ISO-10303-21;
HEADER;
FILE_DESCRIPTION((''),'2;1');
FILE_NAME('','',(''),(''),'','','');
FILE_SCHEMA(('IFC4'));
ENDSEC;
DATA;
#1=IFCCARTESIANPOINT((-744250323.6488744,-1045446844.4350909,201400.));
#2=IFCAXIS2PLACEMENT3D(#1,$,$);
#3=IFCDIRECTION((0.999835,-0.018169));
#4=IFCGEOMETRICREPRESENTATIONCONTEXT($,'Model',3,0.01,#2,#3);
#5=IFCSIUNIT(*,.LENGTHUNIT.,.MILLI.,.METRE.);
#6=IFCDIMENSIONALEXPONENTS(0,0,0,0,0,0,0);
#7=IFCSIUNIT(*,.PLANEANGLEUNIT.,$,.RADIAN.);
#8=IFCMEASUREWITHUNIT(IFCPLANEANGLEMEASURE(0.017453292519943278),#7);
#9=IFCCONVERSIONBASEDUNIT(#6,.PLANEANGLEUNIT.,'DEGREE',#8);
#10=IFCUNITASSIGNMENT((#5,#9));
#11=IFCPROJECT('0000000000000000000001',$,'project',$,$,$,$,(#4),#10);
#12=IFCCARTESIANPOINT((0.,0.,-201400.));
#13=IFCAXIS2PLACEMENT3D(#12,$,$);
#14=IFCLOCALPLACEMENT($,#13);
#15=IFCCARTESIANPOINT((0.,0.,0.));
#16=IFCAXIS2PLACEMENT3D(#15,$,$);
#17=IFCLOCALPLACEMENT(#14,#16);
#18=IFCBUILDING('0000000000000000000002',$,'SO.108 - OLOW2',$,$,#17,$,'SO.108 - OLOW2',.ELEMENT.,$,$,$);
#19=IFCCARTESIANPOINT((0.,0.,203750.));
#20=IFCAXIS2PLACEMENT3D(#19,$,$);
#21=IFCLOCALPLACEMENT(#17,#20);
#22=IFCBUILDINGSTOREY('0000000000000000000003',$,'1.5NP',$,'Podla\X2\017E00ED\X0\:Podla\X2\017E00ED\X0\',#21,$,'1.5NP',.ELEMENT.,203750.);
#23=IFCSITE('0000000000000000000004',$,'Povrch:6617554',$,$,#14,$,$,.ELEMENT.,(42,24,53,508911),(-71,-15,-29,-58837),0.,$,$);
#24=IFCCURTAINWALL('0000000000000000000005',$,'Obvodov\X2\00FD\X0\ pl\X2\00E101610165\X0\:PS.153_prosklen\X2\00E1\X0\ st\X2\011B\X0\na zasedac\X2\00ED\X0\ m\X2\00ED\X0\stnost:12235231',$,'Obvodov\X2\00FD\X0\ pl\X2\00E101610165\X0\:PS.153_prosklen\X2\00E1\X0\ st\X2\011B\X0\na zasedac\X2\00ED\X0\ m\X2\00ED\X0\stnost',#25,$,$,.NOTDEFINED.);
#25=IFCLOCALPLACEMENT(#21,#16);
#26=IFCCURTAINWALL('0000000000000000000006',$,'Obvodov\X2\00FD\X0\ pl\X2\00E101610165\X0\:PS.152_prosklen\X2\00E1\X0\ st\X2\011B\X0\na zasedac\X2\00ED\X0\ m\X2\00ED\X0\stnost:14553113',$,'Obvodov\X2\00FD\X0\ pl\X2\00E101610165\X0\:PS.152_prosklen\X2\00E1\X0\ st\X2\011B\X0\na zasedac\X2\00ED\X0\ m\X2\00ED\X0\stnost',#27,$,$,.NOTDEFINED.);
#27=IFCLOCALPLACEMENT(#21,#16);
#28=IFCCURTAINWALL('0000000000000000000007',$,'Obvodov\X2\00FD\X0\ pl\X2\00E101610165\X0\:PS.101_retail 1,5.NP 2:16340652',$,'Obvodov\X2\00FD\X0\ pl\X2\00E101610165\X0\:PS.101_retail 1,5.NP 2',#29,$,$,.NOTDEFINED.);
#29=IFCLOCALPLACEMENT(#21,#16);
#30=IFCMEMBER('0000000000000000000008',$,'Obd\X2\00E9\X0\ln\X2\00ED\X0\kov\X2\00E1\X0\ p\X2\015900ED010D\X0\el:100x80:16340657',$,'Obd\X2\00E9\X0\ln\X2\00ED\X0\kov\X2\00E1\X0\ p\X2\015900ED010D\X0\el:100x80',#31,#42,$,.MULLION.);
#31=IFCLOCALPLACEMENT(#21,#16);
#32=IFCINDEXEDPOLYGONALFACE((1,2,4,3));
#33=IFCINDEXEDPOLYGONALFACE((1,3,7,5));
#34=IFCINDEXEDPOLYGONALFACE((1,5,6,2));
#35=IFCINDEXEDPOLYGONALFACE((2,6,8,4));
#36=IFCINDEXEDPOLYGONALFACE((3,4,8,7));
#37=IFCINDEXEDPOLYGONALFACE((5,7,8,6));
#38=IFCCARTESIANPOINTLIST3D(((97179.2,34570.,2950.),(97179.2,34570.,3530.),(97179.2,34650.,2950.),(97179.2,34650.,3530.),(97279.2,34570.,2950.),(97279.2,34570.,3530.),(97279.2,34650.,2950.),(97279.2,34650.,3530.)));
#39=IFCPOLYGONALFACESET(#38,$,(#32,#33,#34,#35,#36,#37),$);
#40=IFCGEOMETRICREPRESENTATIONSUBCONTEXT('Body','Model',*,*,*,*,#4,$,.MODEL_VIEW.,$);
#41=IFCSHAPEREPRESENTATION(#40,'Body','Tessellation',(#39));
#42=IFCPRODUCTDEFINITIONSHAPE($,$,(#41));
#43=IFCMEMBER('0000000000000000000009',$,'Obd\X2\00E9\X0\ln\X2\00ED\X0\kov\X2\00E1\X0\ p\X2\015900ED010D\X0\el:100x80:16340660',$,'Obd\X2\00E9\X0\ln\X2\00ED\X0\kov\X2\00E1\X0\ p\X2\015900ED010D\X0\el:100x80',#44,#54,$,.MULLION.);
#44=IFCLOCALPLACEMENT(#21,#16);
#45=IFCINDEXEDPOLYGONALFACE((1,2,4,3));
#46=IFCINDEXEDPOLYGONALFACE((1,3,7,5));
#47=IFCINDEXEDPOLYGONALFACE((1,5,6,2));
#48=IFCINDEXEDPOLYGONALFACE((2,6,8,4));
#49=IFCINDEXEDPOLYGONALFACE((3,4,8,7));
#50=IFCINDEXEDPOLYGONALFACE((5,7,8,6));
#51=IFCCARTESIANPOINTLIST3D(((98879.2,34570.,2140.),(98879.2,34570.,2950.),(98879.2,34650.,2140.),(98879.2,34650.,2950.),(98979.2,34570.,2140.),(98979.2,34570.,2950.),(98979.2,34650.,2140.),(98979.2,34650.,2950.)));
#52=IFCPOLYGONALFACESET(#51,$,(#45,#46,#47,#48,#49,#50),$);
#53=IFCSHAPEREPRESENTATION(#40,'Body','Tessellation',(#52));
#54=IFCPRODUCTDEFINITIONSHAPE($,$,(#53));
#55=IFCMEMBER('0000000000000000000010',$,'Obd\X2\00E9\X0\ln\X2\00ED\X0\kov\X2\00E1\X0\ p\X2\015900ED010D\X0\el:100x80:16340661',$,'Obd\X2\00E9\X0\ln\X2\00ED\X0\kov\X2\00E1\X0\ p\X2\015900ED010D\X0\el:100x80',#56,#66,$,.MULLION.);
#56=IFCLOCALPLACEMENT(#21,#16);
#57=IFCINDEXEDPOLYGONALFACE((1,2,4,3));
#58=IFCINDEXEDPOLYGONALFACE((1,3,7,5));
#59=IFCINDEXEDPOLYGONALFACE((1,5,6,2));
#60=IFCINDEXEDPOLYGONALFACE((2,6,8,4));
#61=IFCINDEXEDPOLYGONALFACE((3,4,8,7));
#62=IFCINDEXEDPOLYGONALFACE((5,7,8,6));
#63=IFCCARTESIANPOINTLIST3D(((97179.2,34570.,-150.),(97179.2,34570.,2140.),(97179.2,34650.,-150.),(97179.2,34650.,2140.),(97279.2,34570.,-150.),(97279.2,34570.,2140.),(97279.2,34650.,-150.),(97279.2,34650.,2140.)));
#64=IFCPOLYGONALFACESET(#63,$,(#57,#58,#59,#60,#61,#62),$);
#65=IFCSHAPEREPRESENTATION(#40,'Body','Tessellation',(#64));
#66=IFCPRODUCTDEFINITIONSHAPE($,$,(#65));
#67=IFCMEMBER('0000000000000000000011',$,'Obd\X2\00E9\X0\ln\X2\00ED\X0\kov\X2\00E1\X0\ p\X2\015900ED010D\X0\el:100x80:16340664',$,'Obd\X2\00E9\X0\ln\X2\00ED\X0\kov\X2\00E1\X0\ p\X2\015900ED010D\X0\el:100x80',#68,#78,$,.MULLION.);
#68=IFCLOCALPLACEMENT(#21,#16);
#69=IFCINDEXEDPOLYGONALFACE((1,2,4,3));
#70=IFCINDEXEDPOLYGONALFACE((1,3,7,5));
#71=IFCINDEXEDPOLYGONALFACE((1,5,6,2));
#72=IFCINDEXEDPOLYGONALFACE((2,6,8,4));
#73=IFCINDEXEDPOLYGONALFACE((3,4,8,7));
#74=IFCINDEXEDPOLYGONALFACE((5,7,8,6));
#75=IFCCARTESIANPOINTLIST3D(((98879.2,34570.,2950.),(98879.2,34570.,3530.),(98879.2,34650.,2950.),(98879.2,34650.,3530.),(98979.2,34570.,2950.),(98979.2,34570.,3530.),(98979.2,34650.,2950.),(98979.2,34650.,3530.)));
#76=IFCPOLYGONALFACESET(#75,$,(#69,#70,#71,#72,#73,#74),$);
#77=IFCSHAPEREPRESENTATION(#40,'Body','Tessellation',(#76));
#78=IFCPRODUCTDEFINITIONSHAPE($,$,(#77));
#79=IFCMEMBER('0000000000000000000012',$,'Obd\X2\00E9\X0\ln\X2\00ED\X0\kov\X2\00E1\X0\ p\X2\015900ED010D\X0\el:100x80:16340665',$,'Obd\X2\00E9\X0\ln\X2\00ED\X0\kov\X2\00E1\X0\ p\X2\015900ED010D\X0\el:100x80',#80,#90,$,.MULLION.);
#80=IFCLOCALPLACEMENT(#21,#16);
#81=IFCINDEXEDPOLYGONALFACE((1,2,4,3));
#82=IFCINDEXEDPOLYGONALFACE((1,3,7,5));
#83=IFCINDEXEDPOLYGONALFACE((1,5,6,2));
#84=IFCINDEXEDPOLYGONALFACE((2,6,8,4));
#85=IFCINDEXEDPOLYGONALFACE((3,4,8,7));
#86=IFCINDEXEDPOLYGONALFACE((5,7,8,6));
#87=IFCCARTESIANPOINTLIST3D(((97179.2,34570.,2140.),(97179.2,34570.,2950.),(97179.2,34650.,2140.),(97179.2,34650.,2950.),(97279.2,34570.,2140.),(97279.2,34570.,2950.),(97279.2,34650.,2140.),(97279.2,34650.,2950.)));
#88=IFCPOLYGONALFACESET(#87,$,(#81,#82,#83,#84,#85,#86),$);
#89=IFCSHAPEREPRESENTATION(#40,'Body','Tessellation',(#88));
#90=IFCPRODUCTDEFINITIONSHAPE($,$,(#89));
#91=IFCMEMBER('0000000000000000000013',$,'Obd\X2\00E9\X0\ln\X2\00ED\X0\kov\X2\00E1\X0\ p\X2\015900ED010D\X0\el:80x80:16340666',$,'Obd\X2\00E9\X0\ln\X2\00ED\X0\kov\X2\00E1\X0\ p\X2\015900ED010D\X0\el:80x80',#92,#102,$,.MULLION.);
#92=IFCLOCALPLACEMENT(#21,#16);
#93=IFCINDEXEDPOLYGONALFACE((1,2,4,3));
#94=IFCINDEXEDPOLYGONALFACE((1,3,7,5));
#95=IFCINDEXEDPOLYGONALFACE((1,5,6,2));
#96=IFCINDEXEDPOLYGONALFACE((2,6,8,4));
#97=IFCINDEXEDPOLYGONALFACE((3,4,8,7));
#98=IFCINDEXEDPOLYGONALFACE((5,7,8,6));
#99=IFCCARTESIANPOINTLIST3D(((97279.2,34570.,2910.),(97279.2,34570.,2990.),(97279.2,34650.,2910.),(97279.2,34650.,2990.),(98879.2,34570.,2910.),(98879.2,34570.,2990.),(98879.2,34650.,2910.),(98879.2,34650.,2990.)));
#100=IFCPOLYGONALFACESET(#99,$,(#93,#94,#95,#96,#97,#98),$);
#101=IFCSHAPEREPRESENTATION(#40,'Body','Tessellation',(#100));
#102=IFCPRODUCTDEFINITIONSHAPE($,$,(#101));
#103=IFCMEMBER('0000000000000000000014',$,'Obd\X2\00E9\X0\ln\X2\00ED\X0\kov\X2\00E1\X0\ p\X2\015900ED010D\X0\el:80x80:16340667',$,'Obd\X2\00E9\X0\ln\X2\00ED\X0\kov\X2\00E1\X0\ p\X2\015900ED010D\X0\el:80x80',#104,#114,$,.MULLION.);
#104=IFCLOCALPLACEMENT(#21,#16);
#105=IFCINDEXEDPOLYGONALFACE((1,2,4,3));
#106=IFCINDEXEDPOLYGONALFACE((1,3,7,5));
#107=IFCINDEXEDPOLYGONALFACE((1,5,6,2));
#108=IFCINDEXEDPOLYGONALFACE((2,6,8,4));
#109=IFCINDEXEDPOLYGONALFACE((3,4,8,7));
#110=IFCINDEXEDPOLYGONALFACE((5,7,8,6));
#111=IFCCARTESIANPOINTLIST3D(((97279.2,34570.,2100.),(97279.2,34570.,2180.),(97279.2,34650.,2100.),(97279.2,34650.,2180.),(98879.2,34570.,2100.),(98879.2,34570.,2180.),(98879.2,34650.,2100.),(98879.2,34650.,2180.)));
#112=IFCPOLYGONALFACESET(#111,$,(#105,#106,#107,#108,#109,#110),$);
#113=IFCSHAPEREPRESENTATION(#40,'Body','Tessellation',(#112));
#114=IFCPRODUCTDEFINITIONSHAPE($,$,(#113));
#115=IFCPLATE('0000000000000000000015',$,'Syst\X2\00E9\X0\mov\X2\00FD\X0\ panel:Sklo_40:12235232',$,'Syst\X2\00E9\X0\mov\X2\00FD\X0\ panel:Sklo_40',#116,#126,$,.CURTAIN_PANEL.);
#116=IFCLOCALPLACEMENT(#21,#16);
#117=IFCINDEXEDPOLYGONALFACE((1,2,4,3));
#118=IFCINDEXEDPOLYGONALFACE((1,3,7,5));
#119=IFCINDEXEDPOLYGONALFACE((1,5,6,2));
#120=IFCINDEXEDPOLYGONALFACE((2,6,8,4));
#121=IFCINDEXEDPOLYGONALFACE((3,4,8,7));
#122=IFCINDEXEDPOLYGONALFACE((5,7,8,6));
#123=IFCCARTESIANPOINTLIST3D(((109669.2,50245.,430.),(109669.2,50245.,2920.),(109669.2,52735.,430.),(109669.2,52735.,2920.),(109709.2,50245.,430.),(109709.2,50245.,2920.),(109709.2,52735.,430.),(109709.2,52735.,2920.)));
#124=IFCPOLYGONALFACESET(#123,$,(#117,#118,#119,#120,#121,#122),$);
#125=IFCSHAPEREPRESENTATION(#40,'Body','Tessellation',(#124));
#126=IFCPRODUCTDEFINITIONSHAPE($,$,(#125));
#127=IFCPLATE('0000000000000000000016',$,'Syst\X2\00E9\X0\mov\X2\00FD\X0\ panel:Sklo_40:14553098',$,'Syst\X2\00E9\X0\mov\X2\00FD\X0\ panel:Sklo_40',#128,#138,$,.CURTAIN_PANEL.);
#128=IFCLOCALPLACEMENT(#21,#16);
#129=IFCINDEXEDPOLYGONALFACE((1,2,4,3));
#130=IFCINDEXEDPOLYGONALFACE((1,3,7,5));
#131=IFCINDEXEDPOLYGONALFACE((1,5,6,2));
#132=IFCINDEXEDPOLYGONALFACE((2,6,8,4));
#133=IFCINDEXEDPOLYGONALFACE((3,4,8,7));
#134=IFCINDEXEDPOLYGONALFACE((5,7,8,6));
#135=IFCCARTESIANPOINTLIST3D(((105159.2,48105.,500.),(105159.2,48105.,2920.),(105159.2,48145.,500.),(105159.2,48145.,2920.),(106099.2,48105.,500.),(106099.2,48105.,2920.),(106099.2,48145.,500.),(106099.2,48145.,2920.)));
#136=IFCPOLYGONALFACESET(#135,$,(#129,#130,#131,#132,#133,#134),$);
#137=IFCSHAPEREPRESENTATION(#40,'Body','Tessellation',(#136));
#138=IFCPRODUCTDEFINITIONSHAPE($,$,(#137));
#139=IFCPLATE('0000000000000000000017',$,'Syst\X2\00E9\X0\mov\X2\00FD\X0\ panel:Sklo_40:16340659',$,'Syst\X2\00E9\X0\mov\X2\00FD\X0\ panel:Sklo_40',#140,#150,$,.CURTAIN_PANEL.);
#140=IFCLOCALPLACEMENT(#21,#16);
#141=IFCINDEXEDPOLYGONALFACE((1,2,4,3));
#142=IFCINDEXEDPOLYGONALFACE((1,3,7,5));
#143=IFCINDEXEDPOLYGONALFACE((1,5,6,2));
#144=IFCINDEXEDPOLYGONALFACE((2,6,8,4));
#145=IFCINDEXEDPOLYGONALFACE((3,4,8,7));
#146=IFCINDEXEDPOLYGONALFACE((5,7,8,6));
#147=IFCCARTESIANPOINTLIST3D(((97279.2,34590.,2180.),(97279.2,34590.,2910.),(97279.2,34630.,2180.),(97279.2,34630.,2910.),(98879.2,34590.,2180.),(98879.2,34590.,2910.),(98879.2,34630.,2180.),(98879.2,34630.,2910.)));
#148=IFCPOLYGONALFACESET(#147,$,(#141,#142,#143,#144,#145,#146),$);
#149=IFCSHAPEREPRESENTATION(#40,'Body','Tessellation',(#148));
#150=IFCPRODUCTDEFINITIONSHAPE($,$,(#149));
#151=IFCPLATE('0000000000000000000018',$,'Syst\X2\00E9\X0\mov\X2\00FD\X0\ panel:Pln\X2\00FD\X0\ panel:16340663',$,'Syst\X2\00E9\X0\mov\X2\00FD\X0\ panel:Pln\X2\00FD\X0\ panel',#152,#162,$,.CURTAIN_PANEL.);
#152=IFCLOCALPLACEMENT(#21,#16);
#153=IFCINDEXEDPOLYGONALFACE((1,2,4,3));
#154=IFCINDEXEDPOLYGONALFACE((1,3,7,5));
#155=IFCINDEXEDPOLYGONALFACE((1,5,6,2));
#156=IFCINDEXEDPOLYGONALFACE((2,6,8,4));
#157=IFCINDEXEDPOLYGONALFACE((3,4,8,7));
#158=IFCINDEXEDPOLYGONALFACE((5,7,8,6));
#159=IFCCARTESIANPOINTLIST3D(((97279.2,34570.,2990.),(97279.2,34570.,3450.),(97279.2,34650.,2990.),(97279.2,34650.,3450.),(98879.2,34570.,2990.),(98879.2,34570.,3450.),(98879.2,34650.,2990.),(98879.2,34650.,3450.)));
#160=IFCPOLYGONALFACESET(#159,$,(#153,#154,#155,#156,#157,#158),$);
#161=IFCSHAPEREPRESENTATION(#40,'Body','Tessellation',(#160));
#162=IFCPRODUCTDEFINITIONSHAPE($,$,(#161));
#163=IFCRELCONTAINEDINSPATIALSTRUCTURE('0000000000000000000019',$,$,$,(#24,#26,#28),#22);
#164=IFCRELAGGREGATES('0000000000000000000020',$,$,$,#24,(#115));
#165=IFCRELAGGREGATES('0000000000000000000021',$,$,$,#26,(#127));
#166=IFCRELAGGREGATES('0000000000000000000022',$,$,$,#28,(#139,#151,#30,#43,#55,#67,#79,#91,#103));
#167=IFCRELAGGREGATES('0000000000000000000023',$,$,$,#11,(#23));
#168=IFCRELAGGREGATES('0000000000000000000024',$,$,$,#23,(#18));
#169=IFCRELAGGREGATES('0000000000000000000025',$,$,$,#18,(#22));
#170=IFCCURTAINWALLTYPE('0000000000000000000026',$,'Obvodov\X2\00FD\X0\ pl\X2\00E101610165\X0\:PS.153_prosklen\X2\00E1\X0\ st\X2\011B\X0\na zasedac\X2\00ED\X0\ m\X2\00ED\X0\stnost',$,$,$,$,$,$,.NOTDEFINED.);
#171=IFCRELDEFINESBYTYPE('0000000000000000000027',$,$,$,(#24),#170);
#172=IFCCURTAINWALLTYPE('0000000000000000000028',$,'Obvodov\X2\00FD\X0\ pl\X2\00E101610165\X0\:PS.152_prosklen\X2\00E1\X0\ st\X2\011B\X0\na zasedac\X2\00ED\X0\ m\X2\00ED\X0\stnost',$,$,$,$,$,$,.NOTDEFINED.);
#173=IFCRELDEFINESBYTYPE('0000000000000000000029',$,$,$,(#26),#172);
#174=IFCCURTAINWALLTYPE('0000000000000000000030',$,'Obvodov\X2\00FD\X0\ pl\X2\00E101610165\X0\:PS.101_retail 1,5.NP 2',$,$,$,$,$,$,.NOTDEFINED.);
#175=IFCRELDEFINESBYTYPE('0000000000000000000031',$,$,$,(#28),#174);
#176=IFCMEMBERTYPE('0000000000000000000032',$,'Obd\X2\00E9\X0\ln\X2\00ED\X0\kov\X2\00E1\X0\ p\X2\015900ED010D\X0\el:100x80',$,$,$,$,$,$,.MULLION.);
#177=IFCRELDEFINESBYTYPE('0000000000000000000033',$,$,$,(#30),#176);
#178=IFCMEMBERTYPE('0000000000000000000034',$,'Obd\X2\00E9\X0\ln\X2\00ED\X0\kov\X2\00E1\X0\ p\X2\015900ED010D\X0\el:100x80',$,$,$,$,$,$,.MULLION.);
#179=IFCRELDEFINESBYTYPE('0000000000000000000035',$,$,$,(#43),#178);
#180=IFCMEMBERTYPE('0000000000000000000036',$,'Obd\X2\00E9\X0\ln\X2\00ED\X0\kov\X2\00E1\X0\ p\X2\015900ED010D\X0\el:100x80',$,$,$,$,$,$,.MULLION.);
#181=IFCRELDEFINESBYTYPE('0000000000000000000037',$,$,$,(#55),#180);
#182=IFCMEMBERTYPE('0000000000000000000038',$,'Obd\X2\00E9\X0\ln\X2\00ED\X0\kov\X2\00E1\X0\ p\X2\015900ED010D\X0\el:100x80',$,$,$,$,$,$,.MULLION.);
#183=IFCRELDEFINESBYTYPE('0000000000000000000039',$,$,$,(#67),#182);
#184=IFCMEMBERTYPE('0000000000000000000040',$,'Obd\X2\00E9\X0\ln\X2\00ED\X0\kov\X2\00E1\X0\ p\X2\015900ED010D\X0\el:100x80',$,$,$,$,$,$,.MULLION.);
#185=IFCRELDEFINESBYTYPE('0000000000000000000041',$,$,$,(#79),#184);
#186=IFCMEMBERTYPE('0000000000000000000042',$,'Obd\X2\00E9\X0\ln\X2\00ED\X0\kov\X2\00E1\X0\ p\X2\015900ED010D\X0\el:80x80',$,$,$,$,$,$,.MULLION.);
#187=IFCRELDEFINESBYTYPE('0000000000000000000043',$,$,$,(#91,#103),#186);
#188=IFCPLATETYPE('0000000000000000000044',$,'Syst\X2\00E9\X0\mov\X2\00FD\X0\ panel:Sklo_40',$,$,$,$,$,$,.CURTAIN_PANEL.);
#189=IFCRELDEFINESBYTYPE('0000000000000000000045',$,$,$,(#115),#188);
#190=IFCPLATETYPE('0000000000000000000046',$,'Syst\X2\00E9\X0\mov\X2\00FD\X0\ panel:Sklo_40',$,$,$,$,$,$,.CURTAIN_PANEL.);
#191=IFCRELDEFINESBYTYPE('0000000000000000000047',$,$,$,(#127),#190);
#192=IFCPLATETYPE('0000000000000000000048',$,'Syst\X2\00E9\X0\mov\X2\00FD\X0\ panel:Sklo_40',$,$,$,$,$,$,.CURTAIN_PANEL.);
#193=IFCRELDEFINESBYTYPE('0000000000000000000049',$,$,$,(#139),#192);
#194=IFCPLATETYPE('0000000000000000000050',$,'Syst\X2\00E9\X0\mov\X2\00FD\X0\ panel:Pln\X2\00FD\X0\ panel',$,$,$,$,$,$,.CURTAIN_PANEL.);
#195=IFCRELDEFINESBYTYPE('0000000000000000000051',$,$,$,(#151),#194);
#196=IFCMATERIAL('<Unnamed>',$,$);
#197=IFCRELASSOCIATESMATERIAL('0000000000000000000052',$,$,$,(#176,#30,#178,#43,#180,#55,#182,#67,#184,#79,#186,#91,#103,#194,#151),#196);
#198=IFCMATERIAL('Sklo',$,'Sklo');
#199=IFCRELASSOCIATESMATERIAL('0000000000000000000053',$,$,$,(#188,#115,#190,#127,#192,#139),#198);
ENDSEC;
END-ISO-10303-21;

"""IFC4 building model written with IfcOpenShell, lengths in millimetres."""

from ifc_helpers import new_model, entity, si_unit, converted_unit, direction, frame, origin, place, context, subcontext, project, spatial, indexed_curve, outline, extrude, source, transform, mapped, material, type_object, type_shapes, element, aggregate, save


model = new_model("IFC4")

# Units and contexts
model_context = context("Model", 3, precision=0.01, world=frame((-744250323.6488744, -1045446844.4350909, 201400.0)), true_north=direction((0.999835, -0.018169)))
body_context = subcontext(model_context, "Body", "Model", "MODEL_VIEW")
ifc_project = project(units=[si_unit("LENGTHUNIT", "METRE", prefix="MILLI"), converted_unit("PLANEANGLEUNIT", "DEGREE", entity("IfcPlaneAngleMeasure", 0.017453292519943278), si_unit("PLANEANGLEUNIT", "RADIAN"), dimensions=[0, 0, 0, 0, 0, 0, 0])], contexts=[model_context])

# Site, building, storey
site_placement = place(None, frame((0.0, 0.0, -201400.0)))
site = spatial("IfcSite", under=ifc_project, at=site_placement, Name="Povrch:6617554", CompositionType="ELEMENT", RefLatitude=(42, 24, 53, 508911), RefLongitude=(-71, -15, -29, -58837), RefElevation=0.0)
building_placement = place(site_placement, origin())
building = spatial("IfcBuilding", under=site, at=building_placement, Name="SO.108 - OLOW2", LongName="SO.108 - OLOW2", CompositionType="ELEMENT")
storey_placement = place(building_placement, frame((0.0, 0.0, 203750.0)))
storey = spatial("IfcBuildingStorey", under=building, at=storey_placement, Name="1.5NP", ObjectType="Podlaží:Podlaží", LongName="1.5NP", CompositionType="ELEMENT", Elevation=203750.0)

# Curtain wall
curtain_wall_type_1 = type_object("IfcCurtainWallType", Name="Obvodový plášť:PS.153_prosklená stěna zasedací místnost", PredefinedType="NOTDEFINED")
curtain_wall_1_placement = place(storey_placement, frame((0.0, 0.0, -203750.0)))
curtain_wall_1 = element("IfcCurtainWall", 1, at=curtain_wall_1_placement, inside=storey, type_object=curtain_wall_type_1, Name="Obvodový plášť:PS.153_prosklená stěna zasedací místnost:12235231", ObjectType="Obvodový plášť:PS.153_prosklená stěna zasedací místnost", PredefinedType="NOTDEFINED")
ifc_material_1 = material(Name="<Unnamed>")

# Curtain wall
curtain_wall_type_2 = type_object("IfcCurtainWallType", Name="Obvodový plášť:PS.152_prosklená stěna zasedací místnost", PredefinedType="NOTDEFINED")
curtain_wall_2_placement = place(storey_placement, frame((0.0, 0.0, -203750.0)))
curtain_wall_2 = element("IfcCurtainWall", 2, at=curtain_wall_2_placement, inside=storey, type_object=curtain_wall_type_2, Name="Obvodový plášť:PS.152_prosklená stěna zasedací místnost:14553113", ObjectType="Obvodový plášť:PS.152_prosklená stěna zasedací místnost", PredefinedType="NOTDEFINED")

# Curtain wall, members
curtain_wall_type_3 = type_object("IfcCurtainWallType", Name="Obvodový plášť:PS.101_retail 1,5.NP 2", PredefinedType="NOTDEFINED")
curtain_wall_3_placement = place(storey_placement, frame((0.0, 0.0, -203750.0)))
curtain_wall_3 = element("IfcCurtainWall", 3, at=curtain_wall_3_placement, inside=storey, type_object=curtain_wall_type_3, Name="Obvodový plášť:PS.101_retail 1,5.NP 2:16340652", ObjectType="Obvodový plášť:PS.101_retail 1,5.NP 2", PredefinedType="NOTDEFINED")
member_type_1 = type_object("IfcMemberType", Name="Obdélníková příčel:100x80", PredefinedType="MULLION", material=ifc_material_1)
shared_shape_1 = source(origin(), body_context, "Body", "SweptSolid", [
    extrude(outline(indexed_curve([(-50.0, -40.0), (50.0, -40.0), (50.0, 40.0), (-50.0, 40.0), (-50.0, -40.0)], self_intersect=False)), frame((-50.0, 0.0, -580.0), z_axis=(0.0, 0.0, 1.0), x_axis=(-1.0, 0.0, 0.0)), (0.0, 0.0, 1.0), 580.0),
])
type_shapes(member_type_1, [shared_shape_1])
member_1_placement = place(curtain_wall_3_placement, frame((97179.2, 34610.0, 207280.0), z_axis=(0.0, 0.0, 1.0), x_axis=(-1.0, 0.0, 0.0)))
member_1 = element("IfcMember", 4, at=member_1_placement, type_object=member_type_1, material=ifc_material_1, Name="Obdélníková příčel:100x80:16340657", ObjectType="Obdélníková příčel:100x80", PredefinedType="MULLION", context=body_context, shape_type="MappedRepresentation", body=[
    mapped(shared_shape_1, transform((0.0, 0.0, 0.0), scale=1.0)),
])
member_type_2 = type_object("IfcMemberType", Name="Obdélníková příčel:100x80", PredefinedType="MULLION", material=ifc_material_1)
shared_shape_2 = source(origin(), body_context, "Body", "SweptSolid", [
    extrude(outline(indexed_curve([(-50.0, -40.0), (50.0, -40.0), (50.0, 40.0), (-50.0, 40.0), (-50.0, -40.0)], self_intersect=False)), frame((-50.0, 0.0, -810.0), z_axis=(0.0, 0.0, 1.0), x_axis=(-1.0, 0.0, 0.0)), (0.0, 0.0, 1.0), 810.0),
])
type_shapes(member_type_2, [shared_shape_2])
member_2_placement = place(curtain_wall_3_placement, frame((98979.2, 34610.0, 205890.0), z_axis=(0.0, 0.0, -1.0), x_axis=(1.0, 0.0, 0.0)))
member_2 = element("IfcMember", 5, at=member_2_placement, type_object=member_type_2, material=ifc_material_1, Name="Obdélníková příčel:100x80:16340660", ObjectType="Obdélníková příčel:100x80", PredefinedType="MULLION", context=body_context, shape_type="MappedRepresentation", body=[
    mapped(shared_shape_2, transform((0.0, 0.0, 0.0), scale=1.0)),
])
member_type_3 = type_object("IfcMemberType", Name="Obdélníková příčel:100x80", PredefinedType="MULLION", material=ifc_material_1)
shared_shape_3 = source(origin(), body_context, "Body", "SweptSolid", [
    extrude(outline(indexed_curve([(-50.0, -40.0), (50.0, -40.0), (50.0, 40.0), (-50.0, 40.0), (-50.0, -40.0)], self_intersect=False)), frame((-50.0, 0.0, -2290.0), z_axis=(0.0, 0.0, 1.0), x_axis=(-1.0, 0.0, 0.0)), (0.0, 0.0, 1.0), 2290.0),
])
type_shapes(member_type_3, [shared_shape_3])
member_3_placement = place(curtain_wall_3_placement, frame((97179.2, 34610.0, 205890.0), z_axis=(0.0, 0.0, 1.0), x_axis=(-1.0, 0.0, 0.0)))
member_3 = element("IfcMember", 6, at=member_3_placement, type_object=member_type_3, material=ifc_material_1, Name="Obdélníková příčel:100x80:16340661", ObjectType="Obdélníková příčel:100x80", PredefinedType="MULLION", context=body_context, shape_type="MappedRepresentation", body=[
    mapped(shared_shape_3, transform((0.0, 0.0, 0.0), scale=1.0)),
])
member_type_4 = type_object("IfcMemberType", Name="Obdélníková příčel:100x80", PredefinedType="MULLION", material=ifc_material_1)
shared_shape_4 = source(origin(), body_context, "Body", "SweptSolid", [
    extrude(outline(indexed_curve([(-50.0, -40.0), (50.0, -40.0), (50.0, 40.0), (-50.0, 40.0), (-50.0, -40.0)], self_intersect=False)), frame((-50.0, 0.0, -580.0), z_axis=(0.0, 0.0, 1.0), x_axis=(-1.0, 0.0, 0.0)), (0.0, 0.0, 1.0), 580.0),
])
type_shapes(member_type_4, [shared_shape_4])
member_4_placement = place(curtain_wall_3_placement, frame((98979.2, 34610.0, 206700.0), z_axis=(0.0, 0.0, -1.0), x_axis=(1.0, 0.0, 0.0)))
member_4 = element("IfcMember", 7, at=member_4_placement, type_object=member_type_4, material=ifc_material_1, Name="Obdélníková příčel:100x80:16340664", ObjectType="Obdélníková příčel:100x80", PredefinedType="MULLION", context=body_context, shape_type="MappedRepresentation", body=[
    mapped(shared_shape_4, transform((0.0, 0.0, 0.0), scale=1.0)),
])
member_type_5 = type_object("IfcMemberType", Name="Obdélníková příčel:100x80", PredefinedType="MULLION", material=ifc_material_1)
shared_shape_5 = source(origin(), body_context, "Body", "SweptSolid", [
    extrude(outline(indexed_curve([(-50.0, -40.0), (50.0, -40.0), (50.0, 40.0), (-50.0, 40.0), (-50.0, -40.0)], self_intersect=False)), frame((-50.0, 0.0, -810.0), z_axis=(0.0, 0.0, 1.0), x_axis=(-1.0, 0.0, 0.0)), (0.0, 0.0, 1.0), 810.0),
])
type_shapes(member_type_5, [shared_shape_5])
member_5_placement = place(curtain_wall_3_placement, frame((97179.2, 34610.0, 206700.0), z_axis=(0.0, 0.0, 1.0), x_axis=(-1.0, 0.0, 0.0)))
member_5 = element("IfcMember", 8, at=member_5_placement, type_object=member_type_5, material=ifc_material_1, Name="Obdélníková příčel:100x80:16340665", ObjectType="Obdélníková příčel:100x80", PredefinedType="MULLION", context=body_context, shape_type="MappedRepresentation", body=[
    mapped(shared_shape_5, transform((0.0, 0.0, 0.0), scale=1.0)),
])
member_type_6 = type_object("IfcMemberType", Name="Obdélníková příčel:80x80", PredefinedType="MULLION", material=ifc_material_1)
shared_shape_6 = source(origin(), body_context, "Body", "SweptSolid", [
    extrude(outline(indexed_curve([(-40.0, -40.0), (40.0, -40.0), (40.0, 40.0), (-40.0, 40.0), (-40.0, -40.0)], self_intersect=False)), frame((0.0, 0.0, -1600.0), z_axis=(0.0, 0.0, 1.0), x_axis=(-1.0, 0.0, 0.0)), (0.0, 0.0, 1.0), 1600.0),
])
type_shapes(member_type_6, [shared_shape_6])
member_6_placement = place(curtain_wall_3_placement, frame((98879.2, 34610.0, 206700.0), z_axis=(1.0, 0.0, 0.0), x_axis=(0.0, 0.0, 1.0)))
member_6 = element("IfcMember", 9, at=member_6_placement, type_object=member_type_6, material=ifc_material_1, Name="Obdélníková příčel:80x80:16340666", ObjectType="Obdélníková příčel:80x80", PredefinedType="MULLION", context=body_context, shape_type="MappedRepresentation", body=[
    mapped(shared_shape_6, transform((0.0, 0.0, 0.0), scale=1.0)),
])
member_7_placement = place(curtain_wall_3_placement, frame((98879.2, 34610.0, 205890.0), z_axis=(1.0, 0.0, 0.0), x_axis=(0.0, 0.0, 1.0)))
member_7 = element("IfcMember", 10, at=member_7_placement, type_object=member_type_6, material=ifc_material_1, Name="Obdélníková příčel:80x80:16340667", ObjectType="Obdélníková příčel:80x80", PredefinedType="MULLION", context=body_context, shape_type="MappedRepresentation", body=[
    mapped(shared_shape_6, transform((0.0, 0.0, 0.0), scale=1.0)),
])

# Plates
ifc_material_2 = material(Name="Sklo", Category="Sklo")
plate_type_1 = type_object("IfcPlateType", Name="Systémový panel:Sklo_40", PredefinedType="CURTAIN_PANEL", material=ifc_material_2)
shared_shape_7 = source(origin(), body_context, "Body", "SweptSolid", [
    extrude(outline(indexed_curve([(-20.0, -1245.0), (20.0, -1245.0), (20.0, 1245.0), (-20.0, 1245.0), (-20.0, -1245.0)], self_intersect=False)), frame((0.0, 0.0, 0.0), z_axis=(0.0, 0.0, 1.0), x_axis=(0.0, 1.0, 0.0)), (0.0, 0.0, 1.0), 2490.0),
])
type_shapes(plate_type_1, [shared_shape_7])
plate_1_placement = place(curtain_wall_1_placement, frame((109689.2, 51490.0, 204180.0), z_axis=(0.0, 0.0, 1.0), x_axis=(0.0, 1.0, 0.0)))
plate_1 = element("IfcPlate", 11, at=plate_1_placement, type_object=plate_type_1, material=ifc_material_2, Name="Systémový panel:Sklo_40:12235232", ObjectType="Systémový panel:Sklo_40", PredefinedType="CURTAIN_PANEL", context=body_context, shape_type="MappedRepresentation", body=[
    mapped(shared_shape_7, transform((0.0, 0.0, 0.0), scale=1.0)),
])
aggregate(curtain_wall_1, [plate_1])
plate_type_2 = type_object("IfcPlateType", Name="Systémový panel:Sklo_40", PredefinedType="CURTAIN_PANEL", material=ifc_material_2)
shared_shape_8 = source(origin(), body_context, "Body", "SweptSolid", [
    extrude(outline(indexed_curve([(-20.0, -470.0), (20.0, -470.0), (20.0, 470.0), (-20.0, 470.0), (-20.0, -470.0)], self_intersect=False)), frame((0.0, 0.0, 0.0), z_axis=(0.0, 0.0, 1.0), x_axis=(0.0, 1.0, 0.0)), (0.0, 0.0, 1.0), 2420.0),
])
type_shapes(plate_type_2, [shared_shape_8])
plate_2_placement = place(curtain_wall_2_placement, frame((105629.2, 48125.0, 204250.0)))
plate_2 = element("IfcPlate", 12, at=plate_2_placement, type_object=plate_type_2, material=ifc_material_2, Name="Systémový panel:Sklo_40:14553098", ObjectType="Systémový panel:Sklo_40", PredefinedType="CURTAIN_PANEL", context=body_context, shape_type="MappedRepresentation", body=[
    mapped(shared_shape_8, transform((0.0, 0.0, 0.0), scale=1.0)),
])
aggregate(curtain_wall_2, [plate_2])
plate_type_3 = type_object("IfcPlateType", Name="Systémový panel:Sklo_40", PredefinedType="CURTAIN_PANEL", material=ifc_material_2)
shared_shape_9 = source(origin(), body_context, "Body", "SweptSolid", [
    extrude(outline(indexed_curve([(-20.0, -800.0), (20.0, -800.0), (20.0, 800.0), (-20.0, 800.0), (-20.0, -800.0)], self_intersect=False)), frame((0.0, 0.0, 0.0), z_axis=(0.0, 0.0, 1.0), x_axis=(0.0, 1.0, 0.0)), (0.0, 0.0, 1.0), 730.0),
])
type_shapes(plate_type_3, [shared_shape_9])
plate_3_placement = place(curtain_wall_3_placement, frame((98079.2, 34610.0, 205930.0)))
plate_3 = element("IfcPlate", 13, at=plate_3_placement, type_object=plate_type_3, material=ifc_material_2, Name="Systémový panel:Sklo_40:16340659", ObjectType="Systémový panel:Sklo_40", PredefinedType="CURTAIN_PANEL", context=body_context, shape_type="MappedRepresentation", body=[
    mapped(shared_shape_9, transform((0.0, 0.0, 0.0), scale=1.0)),
])
plate_type_4 = type_object("IfcPlateType", Name="Systémový panel:Plný panel", PredefinedType="CURTAIN_PANEL", material=ifc_material_1)
shared_shape_10 = source(origin(), body_context, "Body", "SweptSolid", [
    extrude(outline(indexed_curve([(-40.0, -800.0), (40.0, -800.0), (40.0, 800.0), (-40.0, 800.0), (-40.0, -800.0)], self_intersect=False)), frame((0.0, 0.0, 0.0), z_axis=(0.0, 0.0, 1.0), x_axis=(0.0, 1.0, 0.0)), (0.0, 0.0, 1.0), 460.0),
])
type_shapes(plate_type_4, [shared_shape_10])
plate_4_placement = place(curtain_wall_3_placement, frame((98079.2, 34610.0, 206740.0)))
plate_4 = element("IfcPlate", 14, at=plate_4_placement, type_object=plate_type_4, material=ifc_material_1, Name="Systémový panel:Plný panel:16340663", ObjectType="Systémový panel:Plný panel", PredefinedType="CURTAIN_PANEL", context=body_context, shape_type="MappedRepresentation", body=[
    mapped(shared_shape_10, transform((0.0, 0.0, 0.0), scale=1.0)),
])

aggregate(curtain_wall_3, [plate_3, plate_4, member_1, member_2, member_3, member_4, member_5, member_6, member_7])

save(model, "model.ifc")
